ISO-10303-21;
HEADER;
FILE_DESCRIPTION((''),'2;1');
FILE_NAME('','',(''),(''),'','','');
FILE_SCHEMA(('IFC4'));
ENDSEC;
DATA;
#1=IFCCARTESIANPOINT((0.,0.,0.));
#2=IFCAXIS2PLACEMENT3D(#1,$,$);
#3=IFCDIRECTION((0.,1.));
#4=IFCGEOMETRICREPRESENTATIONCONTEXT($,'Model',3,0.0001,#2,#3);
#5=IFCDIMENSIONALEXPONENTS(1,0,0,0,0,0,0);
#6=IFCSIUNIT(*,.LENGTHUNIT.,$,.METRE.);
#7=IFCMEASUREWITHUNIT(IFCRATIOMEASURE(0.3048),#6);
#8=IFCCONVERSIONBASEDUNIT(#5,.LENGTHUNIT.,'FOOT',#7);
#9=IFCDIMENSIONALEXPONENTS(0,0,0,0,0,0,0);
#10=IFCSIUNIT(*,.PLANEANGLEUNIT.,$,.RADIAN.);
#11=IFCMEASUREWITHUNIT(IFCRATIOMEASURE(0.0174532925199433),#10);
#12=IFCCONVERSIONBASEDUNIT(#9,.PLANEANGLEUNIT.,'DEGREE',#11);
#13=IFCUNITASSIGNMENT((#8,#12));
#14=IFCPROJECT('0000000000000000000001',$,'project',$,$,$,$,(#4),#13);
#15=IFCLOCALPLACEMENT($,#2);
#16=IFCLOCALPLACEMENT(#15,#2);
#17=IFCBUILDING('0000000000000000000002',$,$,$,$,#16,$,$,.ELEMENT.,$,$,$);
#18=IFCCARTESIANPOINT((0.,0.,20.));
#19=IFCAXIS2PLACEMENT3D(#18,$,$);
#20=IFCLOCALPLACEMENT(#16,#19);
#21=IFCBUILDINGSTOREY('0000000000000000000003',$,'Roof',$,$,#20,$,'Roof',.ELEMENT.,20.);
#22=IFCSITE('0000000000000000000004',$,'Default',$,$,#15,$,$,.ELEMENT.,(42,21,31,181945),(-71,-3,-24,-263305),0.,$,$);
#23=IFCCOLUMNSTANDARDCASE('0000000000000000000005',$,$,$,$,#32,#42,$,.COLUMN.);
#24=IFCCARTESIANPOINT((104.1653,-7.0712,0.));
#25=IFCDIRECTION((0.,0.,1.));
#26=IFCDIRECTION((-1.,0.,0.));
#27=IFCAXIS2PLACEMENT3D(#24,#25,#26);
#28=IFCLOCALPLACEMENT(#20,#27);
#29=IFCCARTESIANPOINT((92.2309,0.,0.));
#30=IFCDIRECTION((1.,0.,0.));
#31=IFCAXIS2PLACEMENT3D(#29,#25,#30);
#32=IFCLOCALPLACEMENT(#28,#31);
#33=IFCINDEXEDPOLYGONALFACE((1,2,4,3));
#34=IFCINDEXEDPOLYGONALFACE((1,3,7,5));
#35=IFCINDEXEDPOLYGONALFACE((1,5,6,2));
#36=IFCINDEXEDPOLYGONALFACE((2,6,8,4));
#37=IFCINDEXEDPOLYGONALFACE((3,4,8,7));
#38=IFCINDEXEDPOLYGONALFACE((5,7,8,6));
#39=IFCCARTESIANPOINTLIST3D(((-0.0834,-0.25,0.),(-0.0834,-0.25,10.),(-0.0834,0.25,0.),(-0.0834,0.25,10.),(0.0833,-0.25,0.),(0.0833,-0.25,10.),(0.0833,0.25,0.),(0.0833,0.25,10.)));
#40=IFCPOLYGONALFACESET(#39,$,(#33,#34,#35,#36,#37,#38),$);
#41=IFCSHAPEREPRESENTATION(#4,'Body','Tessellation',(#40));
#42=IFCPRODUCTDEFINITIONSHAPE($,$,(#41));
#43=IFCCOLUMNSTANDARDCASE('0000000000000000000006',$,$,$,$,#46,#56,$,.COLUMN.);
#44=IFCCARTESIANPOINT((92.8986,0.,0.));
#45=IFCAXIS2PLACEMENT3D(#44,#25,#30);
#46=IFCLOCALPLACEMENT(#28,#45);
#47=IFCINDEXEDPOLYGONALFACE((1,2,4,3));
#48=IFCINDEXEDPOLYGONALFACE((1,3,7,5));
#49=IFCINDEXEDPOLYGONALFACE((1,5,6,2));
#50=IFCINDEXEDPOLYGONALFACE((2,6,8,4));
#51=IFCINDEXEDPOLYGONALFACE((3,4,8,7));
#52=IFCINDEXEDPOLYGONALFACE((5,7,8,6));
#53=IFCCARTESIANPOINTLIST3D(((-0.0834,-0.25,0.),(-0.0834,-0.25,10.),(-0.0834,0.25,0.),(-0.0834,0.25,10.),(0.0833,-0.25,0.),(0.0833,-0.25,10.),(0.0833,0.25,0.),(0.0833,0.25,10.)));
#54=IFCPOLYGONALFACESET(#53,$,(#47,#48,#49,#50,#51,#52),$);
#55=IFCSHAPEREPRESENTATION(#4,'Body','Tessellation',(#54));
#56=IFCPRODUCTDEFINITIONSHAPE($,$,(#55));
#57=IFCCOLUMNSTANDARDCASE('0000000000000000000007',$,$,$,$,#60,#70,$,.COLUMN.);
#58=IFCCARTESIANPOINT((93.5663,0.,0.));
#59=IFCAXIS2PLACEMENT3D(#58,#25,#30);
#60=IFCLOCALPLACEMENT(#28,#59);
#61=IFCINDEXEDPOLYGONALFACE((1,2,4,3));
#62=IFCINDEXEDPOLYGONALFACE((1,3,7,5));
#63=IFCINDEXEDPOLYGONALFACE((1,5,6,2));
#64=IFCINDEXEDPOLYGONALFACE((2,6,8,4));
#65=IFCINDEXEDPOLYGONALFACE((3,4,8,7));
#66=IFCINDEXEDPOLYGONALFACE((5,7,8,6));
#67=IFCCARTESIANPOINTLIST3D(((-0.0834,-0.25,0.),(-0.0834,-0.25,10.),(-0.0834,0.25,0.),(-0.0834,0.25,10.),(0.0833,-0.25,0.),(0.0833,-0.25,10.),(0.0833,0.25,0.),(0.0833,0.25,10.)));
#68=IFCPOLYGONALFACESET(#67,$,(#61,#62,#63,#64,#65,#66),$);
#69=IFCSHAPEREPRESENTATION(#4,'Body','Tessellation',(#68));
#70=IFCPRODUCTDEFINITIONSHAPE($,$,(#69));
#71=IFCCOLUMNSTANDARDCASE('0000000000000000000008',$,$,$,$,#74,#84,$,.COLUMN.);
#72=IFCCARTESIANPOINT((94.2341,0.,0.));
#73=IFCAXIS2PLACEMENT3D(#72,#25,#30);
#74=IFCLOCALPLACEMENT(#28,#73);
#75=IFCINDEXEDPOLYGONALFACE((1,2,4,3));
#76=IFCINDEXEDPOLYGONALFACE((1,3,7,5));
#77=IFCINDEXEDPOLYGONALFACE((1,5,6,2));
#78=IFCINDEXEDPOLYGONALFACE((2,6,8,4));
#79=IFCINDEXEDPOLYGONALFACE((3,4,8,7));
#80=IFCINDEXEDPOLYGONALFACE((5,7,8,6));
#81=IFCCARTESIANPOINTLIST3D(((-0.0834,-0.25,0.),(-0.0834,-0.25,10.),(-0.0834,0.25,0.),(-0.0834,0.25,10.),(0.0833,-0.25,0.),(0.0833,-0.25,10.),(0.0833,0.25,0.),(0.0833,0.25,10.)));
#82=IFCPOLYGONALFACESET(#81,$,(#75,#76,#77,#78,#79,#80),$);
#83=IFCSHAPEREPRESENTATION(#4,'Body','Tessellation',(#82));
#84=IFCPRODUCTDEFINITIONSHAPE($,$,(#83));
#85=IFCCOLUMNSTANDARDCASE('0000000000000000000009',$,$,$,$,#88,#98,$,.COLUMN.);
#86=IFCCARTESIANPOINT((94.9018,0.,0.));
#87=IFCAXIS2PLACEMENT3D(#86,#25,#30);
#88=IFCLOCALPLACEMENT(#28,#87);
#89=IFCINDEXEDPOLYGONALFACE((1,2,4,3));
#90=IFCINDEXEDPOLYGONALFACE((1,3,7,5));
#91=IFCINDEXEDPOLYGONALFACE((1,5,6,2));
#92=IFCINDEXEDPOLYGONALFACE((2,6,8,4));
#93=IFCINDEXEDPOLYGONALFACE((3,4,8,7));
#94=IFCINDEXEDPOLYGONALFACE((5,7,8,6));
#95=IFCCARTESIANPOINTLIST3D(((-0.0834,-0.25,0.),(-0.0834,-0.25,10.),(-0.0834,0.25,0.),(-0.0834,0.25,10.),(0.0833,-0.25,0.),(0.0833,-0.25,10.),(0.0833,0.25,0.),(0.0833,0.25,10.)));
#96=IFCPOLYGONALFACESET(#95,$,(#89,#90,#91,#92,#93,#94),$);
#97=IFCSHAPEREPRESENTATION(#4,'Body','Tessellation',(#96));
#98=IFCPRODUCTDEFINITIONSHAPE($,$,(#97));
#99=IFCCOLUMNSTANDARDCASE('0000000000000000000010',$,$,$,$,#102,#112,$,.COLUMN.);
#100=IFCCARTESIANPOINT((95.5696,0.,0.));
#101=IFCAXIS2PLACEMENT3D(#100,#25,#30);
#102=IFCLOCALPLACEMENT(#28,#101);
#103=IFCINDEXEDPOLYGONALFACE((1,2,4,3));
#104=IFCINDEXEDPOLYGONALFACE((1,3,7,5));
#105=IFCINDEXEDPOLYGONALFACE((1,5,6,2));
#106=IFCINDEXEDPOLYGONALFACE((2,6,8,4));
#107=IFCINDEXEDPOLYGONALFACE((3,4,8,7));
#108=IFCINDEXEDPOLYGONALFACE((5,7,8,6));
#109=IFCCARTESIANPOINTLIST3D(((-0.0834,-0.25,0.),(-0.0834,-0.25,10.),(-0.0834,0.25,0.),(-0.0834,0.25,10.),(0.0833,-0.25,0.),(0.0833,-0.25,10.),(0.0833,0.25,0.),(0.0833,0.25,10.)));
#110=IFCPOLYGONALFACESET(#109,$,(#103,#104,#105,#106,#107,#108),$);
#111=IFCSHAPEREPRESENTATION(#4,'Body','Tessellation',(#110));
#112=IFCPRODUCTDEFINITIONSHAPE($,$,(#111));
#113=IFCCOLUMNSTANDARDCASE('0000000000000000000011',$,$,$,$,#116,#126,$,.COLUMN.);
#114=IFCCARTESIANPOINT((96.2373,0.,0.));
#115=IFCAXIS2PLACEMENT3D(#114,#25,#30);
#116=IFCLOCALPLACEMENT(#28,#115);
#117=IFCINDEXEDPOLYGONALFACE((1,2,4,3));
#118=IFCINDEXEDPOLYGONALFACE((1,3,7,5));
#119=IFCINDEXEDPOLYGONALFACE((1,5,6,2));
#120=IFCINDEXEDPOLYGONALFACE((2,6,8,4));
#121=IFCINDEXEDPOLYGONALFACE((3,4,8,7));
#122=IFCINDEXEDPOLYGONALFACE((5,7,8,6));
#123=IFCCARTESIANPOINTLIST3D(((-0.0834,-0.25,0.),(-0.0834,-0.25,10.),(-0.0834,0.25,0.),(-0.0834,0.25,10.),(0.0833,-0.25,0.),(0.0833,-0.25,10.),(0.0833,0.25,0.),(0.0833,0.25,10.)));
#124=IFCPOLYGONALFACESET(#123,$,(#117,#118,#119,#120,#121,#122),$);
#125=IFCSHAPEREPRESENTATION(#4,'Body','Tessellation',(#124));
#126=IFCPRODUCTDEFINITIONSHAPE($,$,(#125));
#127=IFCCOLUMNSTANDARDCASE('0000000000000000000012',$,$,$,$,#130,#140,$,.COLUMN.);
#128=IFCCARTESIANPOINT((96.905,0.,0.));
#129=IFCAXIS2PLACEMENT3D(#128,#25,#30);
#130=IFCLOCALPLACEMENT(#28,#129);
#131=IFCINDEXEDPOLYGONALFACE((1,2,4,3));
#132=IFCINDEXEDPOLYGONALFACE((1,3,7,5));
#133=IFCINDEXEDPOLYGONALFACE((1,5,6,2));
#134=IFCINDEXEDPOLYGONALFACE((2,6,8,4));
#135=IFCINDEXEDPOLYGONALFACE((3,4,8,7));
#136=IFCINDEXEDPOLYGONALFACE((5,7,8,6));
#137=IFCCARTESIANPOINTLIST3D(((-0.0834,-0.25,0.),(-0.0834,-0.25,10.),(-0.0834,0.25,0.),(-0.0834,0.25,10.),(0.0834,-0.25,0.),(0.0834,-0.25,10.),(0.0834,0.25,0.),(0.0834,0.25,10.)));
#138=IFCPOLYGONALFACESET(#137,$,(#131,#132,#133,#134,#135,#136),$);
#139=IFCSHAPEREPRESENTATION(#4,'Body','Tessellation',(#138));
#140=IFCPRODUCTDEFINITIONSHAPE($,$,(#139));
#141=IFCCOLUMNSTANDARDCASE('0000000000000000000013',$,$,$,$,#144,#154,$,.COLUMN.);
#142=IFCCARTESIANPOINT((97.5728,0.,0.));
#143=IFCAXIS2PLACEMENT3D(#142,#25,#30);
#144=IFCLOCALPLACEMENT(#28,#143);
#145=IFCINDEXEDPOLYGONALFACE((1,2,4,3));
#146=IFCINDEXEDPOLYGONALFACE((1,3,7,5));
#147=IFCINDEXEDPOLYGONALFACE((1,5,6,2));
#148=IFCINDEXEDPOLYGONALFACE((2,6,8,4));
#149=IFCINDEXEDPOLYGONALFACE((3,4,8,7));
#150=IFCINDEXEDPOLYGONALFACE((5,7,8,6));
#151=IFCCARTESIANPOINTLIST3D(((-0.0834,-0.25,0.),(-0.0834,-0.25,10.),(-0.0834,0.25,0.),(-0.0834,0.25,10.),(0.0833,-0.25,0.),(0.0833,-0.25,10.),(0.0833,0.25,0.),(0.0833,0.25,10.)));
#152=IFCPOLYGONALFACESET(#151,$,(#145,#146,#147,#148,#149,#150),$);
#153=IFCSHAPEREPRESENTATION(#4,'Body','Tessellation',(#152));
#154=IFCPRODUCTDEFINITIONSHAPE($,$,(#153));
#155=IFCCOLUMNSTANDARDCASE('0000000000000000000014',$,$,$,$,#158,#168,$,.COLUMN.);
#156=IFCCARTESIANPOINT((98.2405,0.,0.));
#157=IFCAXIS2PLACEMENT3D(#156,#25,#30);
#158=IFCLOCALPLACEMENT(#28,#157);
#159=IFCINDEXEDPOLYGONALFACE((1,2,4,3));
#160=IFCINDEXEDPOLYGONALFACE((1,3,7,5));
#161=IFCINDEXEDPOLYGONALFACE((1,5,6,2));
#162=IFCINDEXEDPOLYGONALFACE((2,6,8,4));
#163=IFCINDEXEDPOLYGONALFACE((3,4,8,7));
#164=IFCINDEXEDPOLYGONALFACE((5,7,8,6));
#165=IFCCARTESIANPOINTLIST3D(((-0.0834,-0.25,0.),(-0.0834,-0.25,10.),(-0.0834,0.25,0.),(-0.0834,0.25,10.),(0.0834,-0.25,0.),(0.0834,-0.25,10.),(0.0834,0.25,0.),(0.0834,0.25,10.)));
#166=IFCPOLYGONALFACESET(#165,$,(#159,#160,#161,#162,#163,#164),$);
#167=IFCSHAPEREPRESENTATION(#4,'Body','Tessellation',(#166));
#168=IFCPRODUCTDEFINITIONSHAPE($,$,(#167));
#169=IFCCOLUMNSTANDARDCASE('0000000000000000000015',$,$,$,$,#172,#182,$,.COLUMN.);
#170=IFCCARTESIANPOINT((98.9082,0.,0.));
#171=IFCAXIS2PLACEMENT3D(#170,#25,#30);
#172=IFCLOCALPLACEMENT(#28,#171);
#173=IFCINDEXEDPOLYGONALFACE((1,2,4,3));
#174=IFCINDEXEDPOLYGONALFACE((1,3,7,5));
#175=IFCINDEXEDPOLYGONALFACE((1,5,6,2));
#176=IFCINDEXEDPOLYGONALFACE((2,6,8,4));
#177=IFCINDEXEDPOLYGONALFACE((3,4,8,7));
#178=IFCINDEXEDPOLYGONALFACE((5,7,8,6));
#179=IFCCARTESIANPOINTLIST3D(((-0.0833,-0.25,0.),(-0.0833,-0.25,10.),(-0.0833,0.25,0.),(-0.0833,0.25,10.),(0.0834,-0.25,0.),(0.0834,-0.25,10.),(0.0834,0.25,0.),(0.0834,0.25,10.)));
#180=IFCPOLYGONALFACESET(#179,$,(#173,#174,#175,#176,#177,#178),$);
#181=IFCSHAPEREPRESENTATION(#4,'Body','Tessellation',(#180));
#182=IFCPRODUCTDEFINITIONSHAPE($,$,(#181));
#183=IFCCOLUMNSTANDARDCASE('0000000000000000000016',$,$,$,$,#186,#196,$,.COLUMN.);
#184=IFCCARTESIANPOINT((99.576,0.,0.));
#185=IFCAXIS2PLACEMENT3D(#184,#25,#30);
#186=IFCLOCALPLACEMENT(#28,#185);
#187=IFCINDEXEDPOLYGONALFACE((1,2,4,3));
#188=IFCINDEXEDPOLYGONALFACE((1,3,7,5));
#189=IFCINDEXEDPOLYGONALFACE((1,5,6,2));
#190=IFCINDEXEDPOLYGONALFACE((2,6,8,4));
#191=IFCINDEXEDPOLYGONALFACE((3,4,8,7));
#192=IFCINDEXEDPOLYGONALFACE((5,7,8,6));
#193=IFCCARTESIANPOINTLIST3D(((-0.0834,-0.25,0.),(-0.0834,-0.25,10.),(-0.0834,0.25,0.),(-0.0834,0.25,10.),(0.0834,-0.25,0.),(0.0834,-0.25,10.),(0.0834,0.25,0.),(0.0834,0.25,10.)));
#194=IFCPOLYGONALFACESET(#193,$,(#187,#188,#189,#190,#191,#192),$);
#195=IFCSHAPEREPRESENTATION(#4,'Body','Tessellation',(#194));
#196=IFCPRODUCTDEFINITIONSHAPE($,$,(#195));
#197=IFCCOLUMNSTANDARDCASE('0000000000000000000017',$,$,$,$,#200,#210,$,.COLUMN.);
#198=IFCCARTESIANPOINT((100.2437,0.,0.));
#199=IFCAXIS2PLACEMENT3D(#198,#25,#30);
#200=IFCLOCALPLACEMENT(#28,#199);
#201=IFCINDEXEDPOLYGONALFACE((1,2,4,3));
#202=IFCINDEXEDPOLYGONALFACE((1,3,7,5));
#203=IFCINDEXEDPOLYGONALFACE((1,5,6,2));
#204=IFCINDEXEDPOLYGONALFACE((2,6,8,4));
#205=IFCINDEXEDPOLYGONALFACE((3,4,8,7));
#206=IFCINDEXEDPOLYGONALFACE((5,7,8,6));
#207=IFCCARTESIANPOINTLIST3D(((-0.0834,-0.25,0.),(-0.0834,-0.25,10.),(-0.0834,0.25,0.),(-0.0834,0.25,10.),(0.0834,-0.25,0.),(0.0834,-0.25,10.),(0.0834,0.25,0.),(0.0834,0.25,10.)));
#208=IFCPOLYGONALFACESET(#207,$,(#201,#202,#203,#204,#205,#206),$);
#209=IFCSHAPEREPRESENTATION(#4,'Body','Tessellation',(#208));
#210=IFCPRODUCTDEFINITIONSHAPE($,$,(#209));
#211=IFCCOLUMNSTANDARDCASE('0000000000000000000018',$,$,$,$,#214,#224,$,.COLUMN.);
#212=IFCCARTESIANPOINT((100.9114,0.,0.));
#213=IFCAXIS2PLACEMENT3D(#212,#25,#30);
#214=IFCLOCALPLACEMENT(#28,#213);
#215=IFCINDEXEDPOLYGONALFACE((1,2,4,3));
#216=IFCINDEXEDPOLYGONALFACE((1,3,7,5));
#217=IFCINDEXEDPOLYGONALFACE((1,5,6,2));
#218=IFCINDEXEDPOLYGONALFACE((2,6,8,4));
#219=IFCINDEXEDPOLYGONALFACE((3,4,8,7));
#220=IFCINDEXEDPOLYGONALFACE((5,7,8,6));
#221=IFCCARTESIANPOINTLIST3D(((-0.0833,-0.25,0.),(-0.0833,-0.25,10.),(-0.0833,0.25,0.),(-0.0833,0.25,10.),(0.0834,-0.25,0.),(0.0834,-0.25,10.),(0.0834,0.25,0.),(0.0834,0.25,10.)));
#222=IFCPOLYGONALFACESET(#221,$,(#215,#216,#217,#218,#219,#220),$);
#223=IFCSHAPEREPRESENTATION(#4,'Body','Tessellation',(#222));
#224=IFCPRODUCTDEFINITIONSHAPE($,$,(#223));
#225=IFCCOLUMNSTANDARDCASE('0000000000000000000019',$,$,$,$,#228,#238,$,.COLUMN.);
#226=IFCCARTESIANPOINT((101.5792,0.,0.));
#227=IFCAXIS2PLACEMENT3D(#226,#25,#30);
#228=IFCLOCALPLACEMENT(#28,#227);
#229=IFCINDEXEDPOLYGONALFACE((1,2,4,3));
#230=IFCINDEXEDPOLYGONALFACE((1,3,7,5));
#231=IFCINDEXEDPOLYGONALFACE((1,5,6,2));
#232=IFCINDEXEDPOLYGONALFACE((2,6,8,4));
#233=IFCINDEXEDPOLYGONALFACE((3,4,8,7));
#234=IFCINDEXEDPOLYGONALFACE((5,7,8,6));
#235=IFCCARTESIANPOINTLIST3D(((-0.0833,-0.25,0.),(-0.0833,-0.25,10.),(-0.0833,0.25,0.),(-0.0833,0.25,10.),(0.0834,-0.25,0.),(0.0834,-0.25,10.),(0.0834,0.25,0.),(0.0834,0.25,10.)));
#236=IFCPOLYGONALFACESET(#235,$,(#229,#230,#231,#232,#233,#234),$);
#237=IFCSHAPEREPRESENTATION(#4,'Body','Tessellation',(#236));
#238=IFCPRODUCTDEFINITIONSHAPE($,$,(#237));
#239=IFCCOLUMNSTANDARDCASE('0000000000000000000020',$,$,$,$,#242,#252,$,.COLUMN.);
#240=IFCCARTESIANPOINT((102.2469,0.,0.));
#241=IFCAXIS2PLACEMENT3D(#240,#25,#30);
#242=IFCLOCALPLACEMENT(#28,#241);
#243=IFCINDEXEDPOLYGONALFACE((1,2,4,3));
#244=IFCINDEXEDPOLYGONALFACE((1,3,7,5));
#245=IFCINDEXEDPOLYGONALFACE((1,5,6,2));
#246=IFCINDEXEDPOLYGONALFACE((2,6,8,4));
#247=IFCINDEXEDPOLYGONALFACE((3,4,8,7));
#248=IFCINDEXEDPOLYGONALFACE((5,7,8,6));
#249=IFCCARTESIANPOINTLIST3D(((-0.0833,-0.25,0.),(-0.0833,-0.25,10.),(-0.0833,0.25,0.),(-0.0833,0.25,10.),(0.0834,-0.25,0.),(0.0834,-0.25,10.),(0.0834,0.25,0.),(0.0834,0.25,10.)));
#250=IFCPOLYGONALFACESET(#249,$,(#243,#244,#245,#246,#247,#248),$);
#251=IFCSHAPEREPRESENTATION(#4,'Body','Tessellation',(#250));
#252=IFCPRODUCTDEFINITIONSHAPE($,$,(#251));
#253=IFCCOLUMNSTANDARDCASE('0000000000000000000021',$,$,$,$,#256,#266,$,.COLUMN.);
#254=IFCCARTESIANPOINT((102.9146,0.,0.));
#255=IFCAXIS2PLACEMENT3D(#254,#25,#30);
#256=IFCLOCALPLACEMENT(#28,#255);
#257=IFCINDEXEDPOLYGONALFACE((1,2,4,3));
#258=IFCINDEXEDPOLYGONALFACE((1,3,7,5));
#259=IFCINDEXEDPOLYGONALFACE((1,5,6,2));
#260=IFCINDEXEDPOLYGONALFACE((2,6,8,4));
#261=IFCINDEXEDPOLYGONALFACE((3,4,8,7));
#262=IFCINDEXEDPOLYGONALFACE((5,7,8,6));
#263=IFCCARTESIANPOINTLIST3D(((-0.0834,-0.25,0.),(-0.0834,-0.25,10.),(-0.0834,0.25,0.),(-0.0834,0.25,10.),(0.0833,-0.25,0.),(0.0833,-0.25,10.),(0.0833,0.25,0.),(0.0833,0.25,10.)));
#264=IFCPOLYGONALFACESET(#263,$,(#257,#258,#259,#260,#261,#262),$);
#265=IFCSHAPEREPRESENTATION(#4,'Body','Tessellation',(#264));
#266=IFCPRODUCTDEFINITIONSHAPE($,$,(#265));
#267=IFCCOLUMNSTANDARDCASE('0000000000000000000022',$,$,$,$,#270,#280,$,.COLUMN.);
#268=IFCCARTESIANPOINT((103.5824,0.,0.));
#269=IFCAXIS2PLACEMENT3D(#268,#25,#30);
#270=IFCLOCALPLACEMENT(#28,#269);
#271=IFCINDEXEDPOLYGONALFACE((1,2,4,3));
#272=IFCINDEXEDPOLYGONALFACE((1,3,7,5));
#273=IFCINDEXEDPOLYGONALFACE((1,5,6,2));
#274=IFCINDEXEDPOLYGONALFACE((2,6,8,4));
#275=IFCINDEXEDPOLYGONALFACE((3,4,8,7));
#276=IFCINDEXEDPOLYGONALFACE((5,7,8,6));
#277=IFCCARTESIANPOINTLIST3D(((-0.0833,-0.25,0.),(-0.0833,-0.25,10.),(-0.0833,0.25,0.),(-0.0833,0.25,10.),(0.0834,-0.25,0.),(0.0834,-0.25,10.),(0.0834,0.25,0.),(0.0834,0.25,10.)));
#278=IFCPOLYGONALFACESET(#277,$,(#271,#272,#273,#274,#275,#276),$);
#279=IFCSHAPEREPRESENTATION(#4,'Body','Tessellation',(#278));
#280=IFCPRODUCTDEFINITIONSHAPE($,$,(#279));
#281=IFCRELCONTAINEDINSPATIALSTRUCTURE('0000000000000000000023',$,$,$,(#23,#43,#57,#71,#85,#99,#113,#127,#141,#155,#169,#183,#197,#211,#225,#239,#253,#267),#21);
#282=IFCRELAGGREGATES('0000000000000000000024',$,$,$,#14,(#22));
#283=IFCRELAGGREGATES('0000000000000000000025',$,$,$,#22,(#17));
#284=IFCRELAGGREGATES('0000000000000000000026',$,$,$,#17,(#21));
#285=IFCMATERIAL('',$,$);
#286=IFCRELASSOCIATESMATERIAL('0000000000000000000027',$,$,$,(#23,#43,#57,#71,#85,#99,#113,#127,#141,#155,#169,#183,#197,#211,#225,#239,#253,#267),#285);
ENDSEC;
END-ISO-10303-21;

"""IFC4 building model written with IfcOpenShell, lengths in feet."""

from ifc_helpers import new_model, entity, si_unit, converted_unit, direction, frame, origin, place, context, project, spatial, rectangle, extrude, material, element, save


model = new_model("IFC4")

# Units and contexts
model_context = context("Model", 3, precision=0.0001, world=origin(), true_north=direction((0.0, 1.0)))
ifc_project = project(units=[converted_unit("LENGTHUNIT", "FOOT", entity("IfcRatioMeasure", 0.3048), si_unit("LENGTHUNIT", "METRE"), dimensions=[1, 0, 0, 0, 0, 0, 0]), converted_unit("PLANEANGLEUNIT", "DEGREE", entity("IfcRatioMeasure", 0.0174532925199433), si_unit("PLANEANGLEUNIT", "RADIAN"), dimensions=[0, 0, 0, 0, 0, 0, 0])], contexts=[model_context])

# Site, building, storey
site_placement = place(None, origin())
site = spatial("IfcSite", under=ifc_project, at=site_placement, Name="Default", CompositionType="ELEMENT", RefLatitude=(42, 21, 31, 181945), RefLongitude=(-71, -3, -24, -263305), RefElevation=0.0)
building_placement = place(site_placement, origin())
building = spatial("IfcBuilding", under=site, at=building_placement, CompositionType="ELEMENT")
storey_placement = place(building_placement, frame((0.0, 0.0, 20.0)))
storey = spatial("IfcBuildingStorey", under=building, at=storey_placement, Name="Roof", LongName="Roof", CompositionType="ELEMENT", Elevation=20.0)

# Columns
ifc_material_1 = material(Name="")
placement_1 = place(storey_placement, frame((104.1653, -7.0712, 0.0), z_axis=(0.0, 0.0, 1.0), x_axis=(-1.0, 0.0, 0.0)))
for number, where, z_axis, x_axis in (
    (1, (92.2309, 0.0, 0.0), (0.0, 0.0, 1.0), (1.0, 0.0, 0.0)),
    (2, (92.8986, 0.0, 0.0), (0.0, 0.0, 1.0), (1.0, 0.0, 0.0)),
    (3, (93.5663, 0.0, 0.0), (0.0, 0.0, 1.0), (1.0, 0.0, 0.0)),
    (4, (94.2341, 0.0, 0.0), (0.0, 0.0, 1.0), (1.0, 0.0, 0.0)),
    (5, (94.9018, 0.0, 0.0), (0.0, 0.0, 1.0), (1.0, 0.0, 0.0)),
    (6, (95.5696, 0.0, 0.0), (0.0, 0.0, 1.0), (1.0, 0.0, 0.0)),
    (7, (96.2373, 0.0, 0.0), (0.0, 0.0, 1.0), (1.0, 0.0, 0.0)),
    (8, (96.905, 0.0, 0.0), (0.0, 0.0, 1.0), (1.0, 0.0, 0.0)),
    (9, (97.5728, 0.0, 0.0), (0.0, 0.0, 1.0), (1.0, 0.0, 0.0)),
    (10, (98.2405, 0.0, 0.0), (0.0, 0.0, 1.0), (1.0, 0.0, 0.0)),
    (11, (98.9082, 0.0, 0.0), (0.0, 0.0, 1.0), (1.0, 0.0, 0.0)),
    (12, (99.576, 0.0, 0.0), (0.0, 0.0, 1.0), (1.0, 0.0, 0.0)),
    (13, (100.2437, 0.0, 0.0), (0.0, 0.0, 1.0), (1.0, 0.0, 0.0)),
    (14, (100.9114, 0.0, 0.0), (0.0, 0.0, 1.0), (1.0, 0.0, 0.0)),
    (15, (101.5792, 0.0, 0.0), (0.0, 0.0, 1.0), (1.0, 0.0, 0.0)),
    (16, (102.2469, 0.0, 0.0), (0.0, 0.0, 1.0), (1.0, 0.0, 0.0)),
    (17, (102.9146, 0.0, 0.0), (0.0, 0.0, 1.0), (1.0, 0.0, 0.0)),
    (18, (103.5824, 0.0, 0.0), (0.0, 0.0, 1.0), (1.0, 0.0, 0.0)),
):
    element("IfcColumnStandardCase", number, at=place(placement_1, frame(where, z_axis=z_axis, x_axis=x_axis)), inside=storey, material=ifc_material_1, PredefinedType="COLUMN", context=model_context, shape_type="SweptSolid", body=[
        extrude(rectangle(XDim=0.1667, YDim=0.5), origin(), (0.0, 0.0, 1.0), 10.0),
    ])

save(model, "model.ifc")
